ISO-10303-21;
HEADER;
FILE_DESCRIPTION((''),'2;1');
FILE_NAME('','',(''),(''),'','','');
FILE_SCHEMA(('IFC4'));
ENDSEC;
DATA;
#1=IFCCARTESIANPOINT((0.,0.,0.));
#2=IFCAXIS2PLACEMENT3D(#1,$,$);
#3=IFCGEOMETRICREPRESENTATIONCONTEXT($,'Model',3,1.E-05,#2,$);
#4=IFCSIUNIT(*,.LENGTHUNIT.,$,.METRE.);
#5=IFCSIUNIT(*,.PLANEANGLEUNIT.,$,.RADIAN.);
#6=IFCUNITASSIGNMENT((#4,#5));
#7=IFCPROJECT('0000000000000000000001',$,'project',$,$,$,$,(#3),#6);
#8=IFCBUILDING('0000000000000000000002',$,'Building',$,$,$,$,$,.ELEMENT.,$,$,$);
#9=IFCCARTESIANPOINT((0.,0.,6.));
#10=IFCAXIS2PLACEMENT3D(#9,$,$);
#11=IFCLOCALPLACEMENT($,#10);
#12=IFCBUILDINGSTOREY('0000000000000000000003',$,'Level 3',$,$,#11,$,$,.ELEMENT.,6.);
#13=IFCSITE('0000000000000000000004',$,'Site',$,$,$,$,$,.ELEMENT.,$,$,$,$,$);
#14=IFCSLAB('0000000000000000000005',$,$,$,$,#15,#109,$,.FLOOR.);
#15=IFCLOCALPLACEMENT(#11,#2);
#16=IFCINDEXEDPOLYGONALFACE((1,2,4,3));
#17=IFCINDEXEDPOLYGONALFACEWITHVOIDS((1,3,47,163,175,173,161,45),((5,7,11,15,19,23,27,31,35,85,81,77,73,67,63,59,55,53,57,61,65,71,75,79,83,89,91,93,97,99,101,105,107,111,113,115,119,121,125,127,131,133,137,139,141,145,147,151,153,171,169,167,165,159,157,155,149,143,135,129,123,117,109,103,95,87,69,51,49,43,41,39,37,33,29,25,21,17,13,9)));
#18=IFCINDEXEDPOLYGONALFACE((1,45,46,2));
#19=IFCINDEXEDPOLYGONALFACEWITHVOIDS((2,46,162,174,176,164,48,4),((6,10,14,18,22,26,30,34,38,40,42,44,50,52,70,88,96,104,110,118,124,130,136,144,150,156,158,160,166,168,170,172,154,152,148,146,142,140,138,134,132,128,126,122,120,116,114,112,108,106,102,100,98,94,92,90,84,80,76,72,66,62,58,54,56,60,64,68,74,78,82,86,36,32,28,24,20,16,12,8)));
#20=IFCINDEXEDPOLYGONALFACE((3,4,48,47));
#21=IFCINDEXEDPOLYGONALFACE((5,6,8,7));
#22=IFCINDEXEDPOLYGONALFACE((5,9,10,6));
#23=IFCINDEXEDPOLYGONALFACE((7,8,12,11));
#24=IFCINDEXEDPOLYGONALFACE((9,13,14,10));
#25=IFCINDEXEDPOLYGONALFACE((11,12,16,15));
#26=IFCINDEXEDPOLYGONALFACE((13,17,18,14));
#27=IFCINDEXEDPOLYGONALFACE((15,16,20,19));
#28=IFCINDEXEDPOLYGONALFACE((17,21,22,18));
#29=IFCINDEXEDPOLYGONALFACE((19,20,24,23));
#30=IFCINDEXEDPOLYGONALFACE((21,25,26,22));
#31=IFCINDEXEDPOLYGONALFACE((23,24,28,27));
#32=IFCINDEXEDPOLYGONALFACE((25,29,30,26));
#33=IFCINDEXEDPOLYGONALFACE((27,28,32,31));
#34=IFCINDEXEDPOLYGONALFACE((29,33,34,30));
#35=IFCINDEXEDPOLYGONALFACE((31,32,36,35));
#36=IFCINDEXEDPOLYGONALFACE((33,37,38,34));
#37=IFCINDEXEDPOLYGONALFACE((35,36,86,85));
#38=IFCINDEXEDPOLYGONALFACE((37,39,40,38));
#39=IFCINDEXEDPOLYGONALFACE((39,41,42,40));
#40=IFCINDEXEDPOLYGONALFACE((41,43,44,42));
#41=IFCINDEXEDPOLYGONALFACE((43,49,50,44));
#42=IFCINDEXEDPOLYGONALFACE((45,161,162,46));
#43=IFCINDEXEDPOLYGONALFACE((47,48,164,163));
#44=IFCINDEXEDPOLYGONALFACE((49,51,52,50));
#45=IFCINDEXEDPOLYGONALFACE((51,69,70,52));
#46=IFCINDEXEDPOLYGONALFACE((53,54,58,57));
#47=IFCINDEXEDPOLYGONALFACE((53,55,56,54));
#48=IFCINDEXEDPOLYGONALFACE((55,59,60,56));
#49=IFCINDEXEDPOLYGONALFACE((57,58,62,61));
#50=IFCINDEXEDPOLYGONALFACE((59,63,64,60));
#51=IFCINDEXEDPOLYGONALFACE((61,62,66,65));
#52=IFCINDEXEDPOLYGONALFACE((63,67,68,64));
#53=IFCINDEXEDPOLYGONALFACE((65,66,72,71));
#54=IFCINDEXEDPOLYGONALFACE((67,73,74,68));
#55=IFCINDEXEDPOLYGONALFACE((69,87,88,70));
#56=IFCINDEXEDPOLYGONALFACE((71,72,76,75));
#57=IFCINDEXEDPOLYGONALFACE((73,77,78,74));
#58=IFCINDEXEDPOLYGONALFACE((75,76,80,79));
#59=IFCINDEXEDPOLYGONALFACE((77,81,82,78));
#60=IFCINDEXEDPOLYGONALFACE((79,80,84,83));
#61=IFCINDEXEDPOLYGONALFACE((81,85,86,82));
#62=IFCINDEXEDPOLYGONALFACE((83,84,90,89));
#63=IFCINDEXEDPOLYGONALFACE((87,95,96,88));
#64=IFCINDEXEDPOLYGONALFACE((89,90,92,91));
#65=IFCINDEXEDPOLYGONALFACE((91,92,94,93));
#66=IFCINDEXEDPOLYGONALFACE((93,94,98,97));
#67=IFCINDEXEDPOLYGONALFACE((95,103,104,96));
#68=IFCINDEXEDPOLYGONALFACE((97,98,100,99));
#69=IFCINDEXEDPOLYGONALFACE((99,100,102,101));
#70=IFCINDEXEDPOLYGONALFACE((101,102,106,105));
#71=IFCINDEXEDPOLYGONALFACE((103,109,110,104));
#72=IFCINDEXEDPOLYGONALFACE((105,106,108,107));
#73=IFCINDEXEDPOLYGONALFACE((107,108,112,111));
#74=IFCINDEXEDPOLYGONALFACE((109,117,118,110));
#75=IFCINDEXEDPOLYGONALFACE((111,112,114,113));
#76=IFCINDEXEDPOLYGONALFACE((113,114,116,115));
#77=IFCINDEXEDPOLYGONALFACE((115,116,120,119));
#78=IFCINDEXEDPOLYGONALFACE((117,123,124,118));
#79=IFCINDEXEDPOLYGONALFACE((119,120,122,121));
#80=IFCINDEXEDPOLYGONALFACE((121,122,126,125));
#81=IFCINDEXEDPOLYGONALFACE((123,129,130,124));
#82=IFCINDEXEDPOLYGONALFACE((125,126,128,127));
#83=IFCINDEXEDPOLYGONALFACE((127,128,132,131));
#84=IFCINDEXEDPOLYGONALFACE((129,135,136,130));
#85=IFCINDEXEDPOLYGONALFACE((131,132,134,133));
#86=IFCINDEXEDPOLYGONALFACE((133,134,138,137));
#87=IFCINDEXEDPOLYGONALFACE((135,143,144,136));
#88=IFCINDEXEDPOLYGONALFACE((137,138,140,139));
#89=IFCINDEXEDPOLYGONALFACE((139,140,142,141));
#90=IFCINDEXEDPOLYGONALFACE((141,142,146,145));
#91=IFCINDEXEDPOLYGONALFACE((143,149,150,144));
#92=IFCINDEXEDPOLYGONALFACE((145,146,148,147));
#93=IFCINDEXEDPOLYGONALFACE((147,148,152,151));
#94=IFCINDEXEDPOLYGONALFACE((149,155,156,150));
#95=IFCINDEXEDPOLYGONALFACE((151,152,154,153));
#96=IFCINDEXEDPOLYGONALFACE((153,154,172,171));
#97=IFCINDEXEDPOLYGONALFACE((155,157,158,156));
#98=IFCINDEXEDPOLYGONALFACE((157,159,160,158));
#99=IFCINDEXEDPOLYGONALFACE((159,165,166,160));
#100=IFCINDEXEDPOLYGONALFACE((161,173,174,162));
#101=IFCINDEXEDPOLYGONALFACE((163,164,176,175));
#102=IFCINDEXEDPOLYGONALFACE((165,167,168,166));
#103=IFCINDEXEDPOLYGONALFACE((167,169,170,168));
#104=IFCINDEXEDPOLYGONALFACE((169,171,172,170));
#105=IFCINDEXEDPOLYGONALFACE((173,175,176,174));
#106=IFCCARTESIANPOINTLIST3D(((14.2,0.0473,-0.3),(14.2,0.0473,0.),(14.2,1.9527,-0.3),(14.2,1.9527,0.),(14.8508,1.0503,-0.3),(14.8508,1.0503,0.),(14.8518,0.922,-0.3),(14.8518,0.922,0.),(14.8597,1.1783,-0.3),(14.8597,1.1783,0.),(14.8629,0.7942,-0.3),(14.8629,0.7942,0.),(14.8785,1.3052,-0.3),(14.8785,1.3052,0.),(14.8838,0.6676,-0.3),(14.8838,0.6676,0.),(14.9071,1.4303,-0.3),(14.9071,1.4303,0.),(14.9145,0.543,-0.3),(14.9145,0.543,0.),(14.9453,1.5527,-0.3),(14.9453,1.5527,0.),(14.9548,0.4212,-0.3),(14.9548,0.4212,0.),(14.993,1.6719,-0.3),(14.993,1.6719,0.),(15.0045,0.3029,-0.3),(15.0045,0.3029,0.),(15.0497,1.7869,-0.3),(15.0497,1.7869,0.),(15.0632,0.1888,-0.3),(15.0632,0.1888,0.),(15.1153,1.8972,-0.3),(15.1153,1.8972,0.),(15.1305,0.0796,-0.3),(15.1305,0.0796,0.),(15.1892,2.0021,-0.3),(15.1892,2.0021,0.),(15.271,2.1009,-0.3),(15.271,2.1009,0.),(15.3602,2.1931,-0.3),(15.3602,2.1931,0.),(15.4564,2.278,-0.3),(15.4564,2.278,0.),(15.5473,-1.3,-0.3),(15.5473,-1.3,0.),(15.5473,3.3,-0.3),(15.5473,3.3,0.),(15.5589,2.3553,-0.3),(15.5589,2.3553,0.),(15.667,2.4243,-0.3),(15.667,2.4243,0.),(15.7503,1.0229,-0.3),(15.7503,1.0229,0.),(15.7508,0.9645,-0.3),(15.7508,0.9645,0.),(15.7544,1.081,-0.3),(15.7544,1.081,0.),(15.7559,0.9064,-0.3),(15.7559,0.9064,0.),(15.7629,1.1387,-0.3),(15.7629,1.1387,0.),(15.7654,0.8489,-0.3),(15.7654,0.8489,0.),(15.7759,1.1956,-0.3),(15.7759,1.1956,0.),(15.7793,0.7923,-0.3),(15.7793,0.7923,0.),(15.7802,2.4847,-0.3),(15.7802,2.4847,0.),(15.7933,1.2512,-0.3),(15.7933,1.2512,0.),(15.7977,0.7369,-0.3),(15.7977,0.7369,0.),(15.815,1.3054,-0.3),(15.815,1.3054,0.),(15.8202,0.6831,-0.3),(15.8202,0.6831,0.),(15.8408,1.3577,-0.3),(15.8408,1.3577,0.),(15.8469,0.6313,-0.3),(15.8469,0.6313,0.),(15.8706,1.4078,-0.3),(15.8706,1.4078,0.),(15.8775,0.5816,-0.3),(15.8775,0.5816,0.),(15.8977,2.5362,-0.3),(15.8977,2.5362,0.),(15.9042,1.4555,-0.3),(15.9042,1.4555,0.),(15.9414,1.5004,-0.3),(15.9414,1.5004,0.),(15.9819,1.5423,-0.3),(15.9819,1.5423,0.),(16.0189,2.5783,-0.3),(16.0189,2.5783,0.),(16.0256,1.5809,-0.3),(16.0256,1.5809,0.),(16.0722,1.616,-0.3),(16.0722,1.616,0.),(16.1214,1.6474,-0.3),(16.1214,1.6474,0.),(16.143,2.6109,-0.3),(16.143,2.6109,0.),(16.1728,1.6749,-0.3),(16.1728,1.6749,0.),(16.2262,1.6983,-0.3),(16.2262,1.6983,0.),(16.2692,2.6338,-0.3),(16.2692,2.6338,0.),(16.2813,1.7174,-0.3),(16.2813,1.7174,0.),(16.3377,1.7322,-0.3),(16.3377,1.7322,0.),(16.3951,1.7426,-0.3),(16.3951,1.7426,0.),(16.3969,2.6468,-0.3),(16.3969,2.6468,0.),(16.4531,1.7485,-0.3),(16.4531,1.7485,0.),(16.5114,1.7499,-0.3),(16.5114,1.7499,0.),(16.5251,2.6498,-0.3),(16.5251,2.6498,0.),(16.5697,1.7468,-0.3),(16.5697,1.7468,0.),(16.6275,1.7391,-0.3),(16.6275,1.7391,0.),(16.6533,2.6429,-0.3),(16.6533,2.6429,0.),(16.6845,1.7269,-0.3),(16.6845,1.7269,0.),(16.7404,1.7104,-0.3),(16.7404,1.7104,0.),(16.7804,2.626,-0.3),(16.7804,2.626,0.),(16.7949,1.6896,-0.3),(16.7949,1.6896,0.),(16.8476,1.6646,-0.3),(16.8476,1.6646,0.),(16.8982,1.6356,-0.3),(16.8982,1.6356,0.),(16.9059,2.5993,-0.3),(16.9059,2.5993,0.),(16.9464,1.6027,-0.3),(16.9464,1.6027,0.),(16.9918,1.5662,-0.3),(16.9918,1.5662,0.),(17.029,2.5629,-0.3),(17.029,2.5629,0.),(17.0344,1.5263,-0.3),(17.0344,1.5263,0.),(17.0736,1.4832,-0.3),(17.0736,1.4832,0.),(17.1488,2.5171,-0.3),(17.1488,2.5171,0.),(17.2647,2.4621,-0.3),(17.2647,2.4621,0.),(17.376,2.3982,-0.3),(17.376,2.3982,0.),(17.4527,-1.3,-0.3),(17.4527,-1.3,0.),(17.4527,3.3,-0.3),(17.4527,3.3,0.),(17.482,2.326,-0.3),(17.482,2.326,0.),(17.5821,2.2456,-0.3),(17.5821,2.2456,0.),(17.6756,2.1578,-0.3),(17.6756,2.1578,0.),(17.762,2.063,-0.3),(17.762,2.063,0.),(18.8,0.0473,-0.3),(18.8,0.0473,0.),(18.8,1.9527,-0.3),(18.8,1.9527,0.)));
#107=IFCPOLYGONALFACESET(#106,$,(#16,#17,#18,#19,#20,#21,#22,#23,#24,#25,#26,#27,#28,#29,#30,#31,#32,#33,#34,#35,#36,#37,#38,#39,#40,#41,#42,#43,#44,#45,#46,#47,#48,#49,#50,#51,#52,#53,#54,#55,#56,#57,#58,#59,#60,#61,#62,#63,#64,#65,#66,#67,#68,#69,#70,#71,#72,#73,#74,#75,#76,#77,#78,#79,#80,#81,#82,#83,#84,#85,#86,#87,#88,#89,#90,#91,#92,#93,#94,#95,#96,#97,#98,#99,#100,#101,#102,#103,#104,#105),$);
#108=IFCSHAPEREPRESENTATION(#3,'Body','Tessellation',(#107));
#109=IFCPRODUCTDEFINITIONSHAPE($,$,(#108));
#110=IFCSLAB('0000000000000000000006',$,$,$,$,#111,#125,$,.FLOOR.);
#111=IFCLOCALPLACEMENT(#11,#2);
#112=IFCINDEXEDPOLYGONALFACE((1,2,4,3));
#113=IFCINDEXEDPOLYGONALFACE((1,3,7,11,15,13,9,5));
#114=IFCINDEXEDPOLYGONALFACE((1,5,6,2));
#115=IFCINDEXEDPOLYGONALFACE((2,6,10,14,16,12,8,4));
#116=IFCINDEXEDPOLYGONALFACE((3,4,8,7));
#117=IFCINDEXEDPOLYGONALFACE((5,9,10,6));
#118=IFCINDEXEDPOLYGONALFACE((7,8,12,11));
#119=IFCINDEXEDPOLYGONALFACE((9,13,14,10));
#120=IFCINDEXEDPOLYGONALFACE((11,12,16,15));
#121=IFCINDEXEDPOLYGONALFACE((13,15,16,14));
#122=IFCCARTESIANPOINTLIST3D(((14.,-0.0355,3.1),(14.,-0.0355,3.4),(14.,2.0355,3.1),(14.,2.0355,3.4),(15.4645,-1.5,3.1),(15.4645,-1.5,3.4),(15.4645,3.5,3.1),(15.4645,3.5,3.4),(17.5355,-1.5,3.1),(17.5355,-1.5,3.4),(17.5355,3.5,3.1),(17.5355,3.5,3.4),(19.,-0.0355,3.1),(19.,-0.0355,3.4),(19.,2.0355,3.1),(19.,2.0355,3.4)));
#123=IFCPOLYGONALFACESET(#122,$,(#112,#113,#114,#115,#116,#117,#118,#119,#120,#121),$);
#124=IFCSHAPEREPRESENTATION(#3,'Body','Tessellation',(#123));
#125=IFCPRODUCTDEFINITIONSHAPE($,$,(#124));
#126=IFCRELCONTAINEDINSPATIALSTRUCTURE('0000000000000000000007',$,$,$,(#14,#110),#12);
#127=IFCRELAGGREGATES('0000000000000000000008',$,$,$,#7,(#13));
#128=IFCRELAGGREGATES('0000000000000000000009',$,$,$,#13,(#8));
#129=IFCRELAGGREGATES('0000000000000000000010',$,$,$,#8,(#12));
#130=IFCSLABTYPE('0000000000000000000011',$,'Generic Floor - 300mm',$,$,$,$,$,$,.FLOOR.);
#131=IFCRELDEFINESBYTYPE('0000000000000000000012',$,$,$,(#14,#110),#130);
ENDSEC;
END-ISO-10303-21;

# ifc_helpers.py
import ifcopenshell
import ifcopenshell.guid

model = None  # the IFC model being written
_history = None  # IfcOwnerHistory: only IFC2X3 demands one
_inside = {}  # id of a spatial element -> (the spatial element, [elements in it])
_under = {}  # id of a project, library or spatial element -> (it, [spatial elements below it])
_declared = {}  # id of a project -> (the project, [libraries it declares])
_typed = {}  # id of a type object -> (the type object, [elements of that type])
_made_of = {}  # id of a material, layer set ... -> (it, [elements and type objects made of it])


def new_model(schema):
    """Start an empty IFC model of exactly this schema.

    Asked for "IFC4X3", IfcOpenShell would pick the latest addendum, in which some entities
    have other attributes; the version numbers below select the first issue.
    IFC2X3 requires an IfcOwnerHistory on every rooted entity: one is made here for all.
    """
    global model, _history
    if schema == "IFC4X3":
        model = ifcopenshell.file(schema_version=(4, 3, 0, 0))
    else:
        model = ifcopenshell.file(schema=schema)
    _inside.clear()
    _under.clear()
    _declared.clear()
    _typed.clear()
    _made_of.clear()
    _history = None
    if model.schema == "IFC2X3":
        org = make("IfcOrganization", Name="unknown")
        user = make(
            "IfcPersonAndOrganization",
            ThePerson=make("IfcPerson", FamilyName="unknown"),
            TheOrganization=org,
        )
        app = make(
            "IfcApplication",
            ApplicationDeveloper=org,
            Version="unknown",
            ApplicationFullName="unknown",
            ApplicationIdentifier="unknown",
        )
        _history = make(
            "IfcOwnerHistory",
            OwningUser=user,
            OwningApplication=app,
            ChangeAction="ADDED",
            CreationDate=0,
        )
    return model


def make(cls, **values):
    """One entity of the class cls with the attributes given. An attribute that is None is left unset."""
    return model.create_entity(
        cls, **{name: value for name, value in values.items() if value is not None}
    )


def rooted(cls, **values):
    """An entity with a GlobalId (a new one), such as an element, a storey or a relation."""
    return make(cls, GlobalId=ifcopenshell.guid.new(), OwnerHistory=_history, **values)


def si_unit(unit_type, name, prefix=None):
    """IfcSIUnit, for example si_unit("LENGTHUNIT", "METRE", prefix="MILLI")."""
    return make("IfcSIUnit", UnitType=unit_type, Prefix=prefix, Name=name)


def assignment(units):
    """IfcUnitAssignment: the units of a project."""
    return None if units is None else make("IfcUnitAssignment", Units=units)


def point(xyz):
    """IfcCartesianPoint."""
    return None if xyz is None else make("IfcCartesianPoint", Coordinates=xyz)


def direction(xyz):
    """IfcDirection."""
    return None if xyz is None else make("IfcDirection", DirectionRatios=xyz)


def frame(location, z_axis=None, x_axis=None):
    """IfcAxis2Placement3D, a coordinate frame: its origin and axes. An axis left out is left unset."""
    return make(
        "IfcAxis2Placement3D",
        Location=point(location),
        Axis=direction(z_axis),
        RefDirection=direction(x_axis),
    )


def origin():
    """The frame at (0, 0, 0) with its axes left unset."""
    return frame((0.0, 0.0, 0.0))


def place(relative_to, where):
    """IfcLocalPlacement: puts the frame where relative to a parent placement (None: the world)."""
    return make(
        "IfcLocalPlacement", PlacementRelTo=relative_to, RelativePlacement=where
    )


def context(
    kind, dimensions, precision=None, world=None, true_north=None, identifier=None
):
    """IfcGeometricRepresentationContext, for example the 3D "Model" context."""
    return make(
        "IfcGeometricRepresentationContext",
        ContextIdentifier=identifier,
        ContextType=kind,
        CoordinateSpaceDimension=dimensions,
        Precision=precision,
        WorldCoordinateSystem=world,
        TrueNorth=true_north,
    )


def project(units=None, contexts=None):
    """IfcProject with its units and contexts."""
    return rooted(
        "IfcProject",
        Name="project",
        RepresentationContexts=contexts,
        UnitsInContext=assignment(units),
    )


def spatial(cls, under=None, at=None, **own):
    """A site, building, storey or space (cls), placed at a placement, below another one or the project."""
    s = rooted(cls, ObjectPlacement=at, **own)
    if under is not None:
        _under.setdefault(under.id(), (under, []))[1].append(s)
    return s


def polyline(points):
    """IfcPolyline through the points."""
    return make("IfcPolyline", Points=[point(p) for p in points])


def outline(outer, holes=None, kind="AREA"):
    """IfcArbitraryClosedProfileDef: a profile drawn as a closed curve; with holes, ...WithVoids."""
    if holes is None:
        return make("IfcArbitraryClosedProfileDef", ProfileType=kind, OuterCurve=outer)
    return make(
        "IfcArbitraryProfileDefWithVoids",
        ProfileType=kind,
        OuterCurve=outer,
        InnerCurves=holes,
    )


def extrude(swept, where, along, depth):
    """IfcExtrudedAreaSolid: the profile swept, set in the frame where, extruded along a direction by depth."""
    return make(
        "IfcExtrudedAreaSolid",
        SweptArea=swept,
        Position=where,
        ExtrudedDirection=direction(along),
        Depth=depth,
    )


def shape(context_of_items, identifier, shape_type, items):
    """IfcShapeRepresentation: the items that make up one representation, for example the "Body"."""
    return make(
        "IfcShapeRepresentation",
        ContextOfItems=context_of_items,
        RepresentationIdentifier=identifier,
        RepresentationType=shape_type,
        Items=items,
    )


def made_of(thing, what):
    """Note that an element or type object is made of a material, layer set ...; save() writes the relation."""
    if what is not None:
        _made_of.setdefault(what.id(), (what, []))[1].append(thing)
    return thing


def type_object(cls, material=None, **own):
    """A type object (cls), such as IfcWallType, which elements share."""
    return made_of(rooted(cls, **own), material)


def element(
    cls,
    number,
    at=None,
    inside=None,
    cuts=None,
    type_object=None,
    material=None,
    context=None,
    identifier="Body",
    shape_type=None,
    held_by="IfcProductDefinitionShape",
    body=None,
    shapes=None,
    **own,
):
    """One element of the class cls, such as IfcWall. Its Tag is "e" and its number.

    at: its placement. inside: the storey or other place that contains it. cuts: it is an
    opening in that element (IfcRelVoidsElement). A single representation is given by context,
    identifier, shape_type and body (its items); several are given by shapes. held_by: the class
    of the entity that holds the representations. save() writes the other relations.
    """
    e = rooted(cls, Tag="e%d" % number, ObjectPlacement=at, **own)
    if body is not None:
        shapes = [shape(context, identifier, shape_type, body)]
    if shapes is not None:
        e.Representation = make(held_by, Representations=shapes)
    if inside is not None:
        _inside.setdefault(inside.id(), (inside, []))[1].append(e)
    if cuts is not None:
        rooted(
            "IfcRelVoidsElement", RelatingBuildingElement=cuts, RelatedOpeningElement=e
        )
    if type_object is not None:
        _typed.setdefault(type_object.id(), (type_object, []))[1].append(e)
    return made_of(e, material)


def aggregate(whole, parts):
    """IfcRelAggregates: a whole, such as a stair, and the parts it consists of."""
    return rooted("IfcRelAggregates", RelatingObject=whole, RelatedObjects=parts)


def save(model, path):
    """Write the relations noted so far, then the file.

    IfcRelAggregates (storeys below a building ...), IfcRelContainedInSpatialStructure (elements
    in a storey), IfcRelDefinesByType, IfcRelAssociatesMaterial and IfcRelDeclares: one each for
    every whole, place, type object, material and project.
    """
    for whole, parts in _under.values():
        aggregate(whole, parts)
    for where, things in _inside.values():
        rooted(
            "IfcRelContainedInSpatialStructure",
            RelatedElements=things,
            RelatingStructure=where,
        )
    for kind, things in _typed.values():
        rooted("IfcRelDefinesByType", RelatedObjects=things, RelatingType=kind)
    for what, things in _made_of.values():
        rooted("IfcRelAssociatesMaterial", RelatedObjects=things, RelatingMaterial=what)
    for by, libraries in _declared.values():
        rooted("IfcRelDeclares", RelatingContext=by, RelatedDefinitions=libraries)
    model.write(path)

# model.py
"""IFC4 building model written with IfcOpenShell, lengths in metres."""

from ifc_helpers import new_model, si_unit, frame, origin, place, context, project, spatial, polyline, outline, extrude, type_object, element, save


model = new_model("IFC4")

# Units and contexts
model_context = context("Model", 3, precision=1e-05, world=origin())
ifc_project = project(units=[si_unit("LENGTHUNIT", "METRE"), si_unit("PLANEANGLEUNIT", "RADIAN")], contexts=[model_context])

# Site, building, storey
site = spatial("IfcSite", under=ifc_project, Name="Site", CompositionType="ELEMENT")
building = spatial("IfcBuilding", under=site, Name="Building", CompositionType="ELEMENT")
storey_placement = place(None, frame((0.0, 0.0, 6.0)))
storey = spatial("IfcBuildingStorey", under=building, at=storey_placement, Name="Level 3", CompositionType="ELEMENT", Elevation=6.0)

# Slab, opening
slab_type = type_object("IfcSlabType", Name="Generic Floor - 300mm", PredefinedType="FLOOR")
slab_1_placement = place(None, frame((0.0, 0.0, 6.0)))
slab_1 = element("IfcSlab", 1, at=slab_1_placement, inside=storey, type_object=slab_type, PredefinedType="FLOOR", context=model_context, shape_type="SweptSolid", body=[
    extrude(outline(polyline([(18.8, 1.9527), (17.4527, 3.3), (15.5473, 3.3), (14.2, 1.9527), (14.2, 0.0473), (15.5473, -1.3), (17.4527, -1.3), (18.8, 0.0473), (18.8, 1.9527)])), origin(), (0.0, 0.0, -1.0), 0.3),
])
opening_1_placement = place(None, frame((0.0, 0.0, 6.001)))
element("IfcOpeningElement", 2, at=opening_1_placement, cuts=slab_1, PredefinedType="OPENING", context=model_context, shape_type="SweptSolid", body=[
    extrude(outline(polyline([(14.8597, 1.1783), (14.8508, 1.0503), (14.8518, 0.922), (14.8629, 0.7942), (14.8838, 0.6676), (14.9145, 0.543), (14.9548, 0.4212), (15.0045, 0.3029), (15.0632, 0.1888), (15.1305, 0.0796), (15.8775, 0.5816), (15.8469, 0.6313), (15.8202, 0.6831), (15.7977, 0.7369), (15.7793, 0.7923), (15.7654, 0.8489), (15.7559, 0.9064), (15.7508, 0.9645), (15.7503, 1.0229), (15.7544, 1.081), (15.7629, 1.1387), (15.7759, 1.1956), (15.7933, 1.2512), (15.815, 1.3054), (15.8408, 1.3577), (15.8706, 1.4078), (15.9042, 1.4555), (15.9414, 1.5004), (15.9819, 1.5423), (16.0256, 1.5809), (16.0722, 1.616), (16.1214, 1.6474), (16.1728, 1.6749), (16.2262, 1.6983), (16.2813, 1.7174), (16.3377, 1.7322), (16.3951, 1.7426), (16.4531, 1.7485), (16.5114, 1.7499), (16.5697, 1.7468), (16.6275, 1.7391), (16.6845, 1.7269), (16.7404, 1.7104), (16.7949, 1.6896), (16.8476, 1.6646), (16.8982, 1.6356), (16.9464, 1.6027), (16.9918, 1.5662), (17.0344, 1.5263), (17.0736, 1.4832), (17.762, 2.063), (17.6756, 2.1578), (17.5821, 2.2456), (17.482, 2.326), (17.376, 2.3982), (17.2647, 2.4621), (17.1488, 2.5171), (17.029, 2.5629), (16.9059, 2.5993), (16.7804, 2.626), (16.6533, 2.6429), (16.5251, 2.6498), (16.3969, 2.6468), (16.2692, 2.6338), (16.143, 2.6109), (16.0189, 2.5783), (15.8977, 2.5362), (15.7802, 2.4847), (15.667, 2.4243), (15.5589, 2.3553), (15.4564, 2.278), (15.3602, 2.1931), (15.271, 2.1009), (15.1892, 2.0021), (15.1153, 1.8972), (15.0497, 1.7869), (14.993, 1.6719), (14.9453, 1.5527), (14.9071, 1.4303), (14.8785, 1.3052), (14.8597, 1.1783)])), origin(), (0.0, 0.0, -1.0), 0.302),
])

# Slab
slab_2_placement = place(None, frame((0.0, 0.0, 9.4)))
element("IfcSlab", 3, at=slab_2_placement, inside=storey, type_object=slab_type, PredefinedType="FLOOR", context=model_context, shape_type="SweptSolid", body=[
    extrude(outline(polyline([(19.0, 2.0355), (17.5355, 3.5), (15.4645, 3.5), (14.0, 2.0355), (14.0, -0.0355), (15.4645, -1.5), (17.5355, -1.5), (19.0, -0.0355), (19.0, 2.0355)])), origin(), (0.0, 0.0, -1.0), 0.3),
])

save(model, "model.ifc")
